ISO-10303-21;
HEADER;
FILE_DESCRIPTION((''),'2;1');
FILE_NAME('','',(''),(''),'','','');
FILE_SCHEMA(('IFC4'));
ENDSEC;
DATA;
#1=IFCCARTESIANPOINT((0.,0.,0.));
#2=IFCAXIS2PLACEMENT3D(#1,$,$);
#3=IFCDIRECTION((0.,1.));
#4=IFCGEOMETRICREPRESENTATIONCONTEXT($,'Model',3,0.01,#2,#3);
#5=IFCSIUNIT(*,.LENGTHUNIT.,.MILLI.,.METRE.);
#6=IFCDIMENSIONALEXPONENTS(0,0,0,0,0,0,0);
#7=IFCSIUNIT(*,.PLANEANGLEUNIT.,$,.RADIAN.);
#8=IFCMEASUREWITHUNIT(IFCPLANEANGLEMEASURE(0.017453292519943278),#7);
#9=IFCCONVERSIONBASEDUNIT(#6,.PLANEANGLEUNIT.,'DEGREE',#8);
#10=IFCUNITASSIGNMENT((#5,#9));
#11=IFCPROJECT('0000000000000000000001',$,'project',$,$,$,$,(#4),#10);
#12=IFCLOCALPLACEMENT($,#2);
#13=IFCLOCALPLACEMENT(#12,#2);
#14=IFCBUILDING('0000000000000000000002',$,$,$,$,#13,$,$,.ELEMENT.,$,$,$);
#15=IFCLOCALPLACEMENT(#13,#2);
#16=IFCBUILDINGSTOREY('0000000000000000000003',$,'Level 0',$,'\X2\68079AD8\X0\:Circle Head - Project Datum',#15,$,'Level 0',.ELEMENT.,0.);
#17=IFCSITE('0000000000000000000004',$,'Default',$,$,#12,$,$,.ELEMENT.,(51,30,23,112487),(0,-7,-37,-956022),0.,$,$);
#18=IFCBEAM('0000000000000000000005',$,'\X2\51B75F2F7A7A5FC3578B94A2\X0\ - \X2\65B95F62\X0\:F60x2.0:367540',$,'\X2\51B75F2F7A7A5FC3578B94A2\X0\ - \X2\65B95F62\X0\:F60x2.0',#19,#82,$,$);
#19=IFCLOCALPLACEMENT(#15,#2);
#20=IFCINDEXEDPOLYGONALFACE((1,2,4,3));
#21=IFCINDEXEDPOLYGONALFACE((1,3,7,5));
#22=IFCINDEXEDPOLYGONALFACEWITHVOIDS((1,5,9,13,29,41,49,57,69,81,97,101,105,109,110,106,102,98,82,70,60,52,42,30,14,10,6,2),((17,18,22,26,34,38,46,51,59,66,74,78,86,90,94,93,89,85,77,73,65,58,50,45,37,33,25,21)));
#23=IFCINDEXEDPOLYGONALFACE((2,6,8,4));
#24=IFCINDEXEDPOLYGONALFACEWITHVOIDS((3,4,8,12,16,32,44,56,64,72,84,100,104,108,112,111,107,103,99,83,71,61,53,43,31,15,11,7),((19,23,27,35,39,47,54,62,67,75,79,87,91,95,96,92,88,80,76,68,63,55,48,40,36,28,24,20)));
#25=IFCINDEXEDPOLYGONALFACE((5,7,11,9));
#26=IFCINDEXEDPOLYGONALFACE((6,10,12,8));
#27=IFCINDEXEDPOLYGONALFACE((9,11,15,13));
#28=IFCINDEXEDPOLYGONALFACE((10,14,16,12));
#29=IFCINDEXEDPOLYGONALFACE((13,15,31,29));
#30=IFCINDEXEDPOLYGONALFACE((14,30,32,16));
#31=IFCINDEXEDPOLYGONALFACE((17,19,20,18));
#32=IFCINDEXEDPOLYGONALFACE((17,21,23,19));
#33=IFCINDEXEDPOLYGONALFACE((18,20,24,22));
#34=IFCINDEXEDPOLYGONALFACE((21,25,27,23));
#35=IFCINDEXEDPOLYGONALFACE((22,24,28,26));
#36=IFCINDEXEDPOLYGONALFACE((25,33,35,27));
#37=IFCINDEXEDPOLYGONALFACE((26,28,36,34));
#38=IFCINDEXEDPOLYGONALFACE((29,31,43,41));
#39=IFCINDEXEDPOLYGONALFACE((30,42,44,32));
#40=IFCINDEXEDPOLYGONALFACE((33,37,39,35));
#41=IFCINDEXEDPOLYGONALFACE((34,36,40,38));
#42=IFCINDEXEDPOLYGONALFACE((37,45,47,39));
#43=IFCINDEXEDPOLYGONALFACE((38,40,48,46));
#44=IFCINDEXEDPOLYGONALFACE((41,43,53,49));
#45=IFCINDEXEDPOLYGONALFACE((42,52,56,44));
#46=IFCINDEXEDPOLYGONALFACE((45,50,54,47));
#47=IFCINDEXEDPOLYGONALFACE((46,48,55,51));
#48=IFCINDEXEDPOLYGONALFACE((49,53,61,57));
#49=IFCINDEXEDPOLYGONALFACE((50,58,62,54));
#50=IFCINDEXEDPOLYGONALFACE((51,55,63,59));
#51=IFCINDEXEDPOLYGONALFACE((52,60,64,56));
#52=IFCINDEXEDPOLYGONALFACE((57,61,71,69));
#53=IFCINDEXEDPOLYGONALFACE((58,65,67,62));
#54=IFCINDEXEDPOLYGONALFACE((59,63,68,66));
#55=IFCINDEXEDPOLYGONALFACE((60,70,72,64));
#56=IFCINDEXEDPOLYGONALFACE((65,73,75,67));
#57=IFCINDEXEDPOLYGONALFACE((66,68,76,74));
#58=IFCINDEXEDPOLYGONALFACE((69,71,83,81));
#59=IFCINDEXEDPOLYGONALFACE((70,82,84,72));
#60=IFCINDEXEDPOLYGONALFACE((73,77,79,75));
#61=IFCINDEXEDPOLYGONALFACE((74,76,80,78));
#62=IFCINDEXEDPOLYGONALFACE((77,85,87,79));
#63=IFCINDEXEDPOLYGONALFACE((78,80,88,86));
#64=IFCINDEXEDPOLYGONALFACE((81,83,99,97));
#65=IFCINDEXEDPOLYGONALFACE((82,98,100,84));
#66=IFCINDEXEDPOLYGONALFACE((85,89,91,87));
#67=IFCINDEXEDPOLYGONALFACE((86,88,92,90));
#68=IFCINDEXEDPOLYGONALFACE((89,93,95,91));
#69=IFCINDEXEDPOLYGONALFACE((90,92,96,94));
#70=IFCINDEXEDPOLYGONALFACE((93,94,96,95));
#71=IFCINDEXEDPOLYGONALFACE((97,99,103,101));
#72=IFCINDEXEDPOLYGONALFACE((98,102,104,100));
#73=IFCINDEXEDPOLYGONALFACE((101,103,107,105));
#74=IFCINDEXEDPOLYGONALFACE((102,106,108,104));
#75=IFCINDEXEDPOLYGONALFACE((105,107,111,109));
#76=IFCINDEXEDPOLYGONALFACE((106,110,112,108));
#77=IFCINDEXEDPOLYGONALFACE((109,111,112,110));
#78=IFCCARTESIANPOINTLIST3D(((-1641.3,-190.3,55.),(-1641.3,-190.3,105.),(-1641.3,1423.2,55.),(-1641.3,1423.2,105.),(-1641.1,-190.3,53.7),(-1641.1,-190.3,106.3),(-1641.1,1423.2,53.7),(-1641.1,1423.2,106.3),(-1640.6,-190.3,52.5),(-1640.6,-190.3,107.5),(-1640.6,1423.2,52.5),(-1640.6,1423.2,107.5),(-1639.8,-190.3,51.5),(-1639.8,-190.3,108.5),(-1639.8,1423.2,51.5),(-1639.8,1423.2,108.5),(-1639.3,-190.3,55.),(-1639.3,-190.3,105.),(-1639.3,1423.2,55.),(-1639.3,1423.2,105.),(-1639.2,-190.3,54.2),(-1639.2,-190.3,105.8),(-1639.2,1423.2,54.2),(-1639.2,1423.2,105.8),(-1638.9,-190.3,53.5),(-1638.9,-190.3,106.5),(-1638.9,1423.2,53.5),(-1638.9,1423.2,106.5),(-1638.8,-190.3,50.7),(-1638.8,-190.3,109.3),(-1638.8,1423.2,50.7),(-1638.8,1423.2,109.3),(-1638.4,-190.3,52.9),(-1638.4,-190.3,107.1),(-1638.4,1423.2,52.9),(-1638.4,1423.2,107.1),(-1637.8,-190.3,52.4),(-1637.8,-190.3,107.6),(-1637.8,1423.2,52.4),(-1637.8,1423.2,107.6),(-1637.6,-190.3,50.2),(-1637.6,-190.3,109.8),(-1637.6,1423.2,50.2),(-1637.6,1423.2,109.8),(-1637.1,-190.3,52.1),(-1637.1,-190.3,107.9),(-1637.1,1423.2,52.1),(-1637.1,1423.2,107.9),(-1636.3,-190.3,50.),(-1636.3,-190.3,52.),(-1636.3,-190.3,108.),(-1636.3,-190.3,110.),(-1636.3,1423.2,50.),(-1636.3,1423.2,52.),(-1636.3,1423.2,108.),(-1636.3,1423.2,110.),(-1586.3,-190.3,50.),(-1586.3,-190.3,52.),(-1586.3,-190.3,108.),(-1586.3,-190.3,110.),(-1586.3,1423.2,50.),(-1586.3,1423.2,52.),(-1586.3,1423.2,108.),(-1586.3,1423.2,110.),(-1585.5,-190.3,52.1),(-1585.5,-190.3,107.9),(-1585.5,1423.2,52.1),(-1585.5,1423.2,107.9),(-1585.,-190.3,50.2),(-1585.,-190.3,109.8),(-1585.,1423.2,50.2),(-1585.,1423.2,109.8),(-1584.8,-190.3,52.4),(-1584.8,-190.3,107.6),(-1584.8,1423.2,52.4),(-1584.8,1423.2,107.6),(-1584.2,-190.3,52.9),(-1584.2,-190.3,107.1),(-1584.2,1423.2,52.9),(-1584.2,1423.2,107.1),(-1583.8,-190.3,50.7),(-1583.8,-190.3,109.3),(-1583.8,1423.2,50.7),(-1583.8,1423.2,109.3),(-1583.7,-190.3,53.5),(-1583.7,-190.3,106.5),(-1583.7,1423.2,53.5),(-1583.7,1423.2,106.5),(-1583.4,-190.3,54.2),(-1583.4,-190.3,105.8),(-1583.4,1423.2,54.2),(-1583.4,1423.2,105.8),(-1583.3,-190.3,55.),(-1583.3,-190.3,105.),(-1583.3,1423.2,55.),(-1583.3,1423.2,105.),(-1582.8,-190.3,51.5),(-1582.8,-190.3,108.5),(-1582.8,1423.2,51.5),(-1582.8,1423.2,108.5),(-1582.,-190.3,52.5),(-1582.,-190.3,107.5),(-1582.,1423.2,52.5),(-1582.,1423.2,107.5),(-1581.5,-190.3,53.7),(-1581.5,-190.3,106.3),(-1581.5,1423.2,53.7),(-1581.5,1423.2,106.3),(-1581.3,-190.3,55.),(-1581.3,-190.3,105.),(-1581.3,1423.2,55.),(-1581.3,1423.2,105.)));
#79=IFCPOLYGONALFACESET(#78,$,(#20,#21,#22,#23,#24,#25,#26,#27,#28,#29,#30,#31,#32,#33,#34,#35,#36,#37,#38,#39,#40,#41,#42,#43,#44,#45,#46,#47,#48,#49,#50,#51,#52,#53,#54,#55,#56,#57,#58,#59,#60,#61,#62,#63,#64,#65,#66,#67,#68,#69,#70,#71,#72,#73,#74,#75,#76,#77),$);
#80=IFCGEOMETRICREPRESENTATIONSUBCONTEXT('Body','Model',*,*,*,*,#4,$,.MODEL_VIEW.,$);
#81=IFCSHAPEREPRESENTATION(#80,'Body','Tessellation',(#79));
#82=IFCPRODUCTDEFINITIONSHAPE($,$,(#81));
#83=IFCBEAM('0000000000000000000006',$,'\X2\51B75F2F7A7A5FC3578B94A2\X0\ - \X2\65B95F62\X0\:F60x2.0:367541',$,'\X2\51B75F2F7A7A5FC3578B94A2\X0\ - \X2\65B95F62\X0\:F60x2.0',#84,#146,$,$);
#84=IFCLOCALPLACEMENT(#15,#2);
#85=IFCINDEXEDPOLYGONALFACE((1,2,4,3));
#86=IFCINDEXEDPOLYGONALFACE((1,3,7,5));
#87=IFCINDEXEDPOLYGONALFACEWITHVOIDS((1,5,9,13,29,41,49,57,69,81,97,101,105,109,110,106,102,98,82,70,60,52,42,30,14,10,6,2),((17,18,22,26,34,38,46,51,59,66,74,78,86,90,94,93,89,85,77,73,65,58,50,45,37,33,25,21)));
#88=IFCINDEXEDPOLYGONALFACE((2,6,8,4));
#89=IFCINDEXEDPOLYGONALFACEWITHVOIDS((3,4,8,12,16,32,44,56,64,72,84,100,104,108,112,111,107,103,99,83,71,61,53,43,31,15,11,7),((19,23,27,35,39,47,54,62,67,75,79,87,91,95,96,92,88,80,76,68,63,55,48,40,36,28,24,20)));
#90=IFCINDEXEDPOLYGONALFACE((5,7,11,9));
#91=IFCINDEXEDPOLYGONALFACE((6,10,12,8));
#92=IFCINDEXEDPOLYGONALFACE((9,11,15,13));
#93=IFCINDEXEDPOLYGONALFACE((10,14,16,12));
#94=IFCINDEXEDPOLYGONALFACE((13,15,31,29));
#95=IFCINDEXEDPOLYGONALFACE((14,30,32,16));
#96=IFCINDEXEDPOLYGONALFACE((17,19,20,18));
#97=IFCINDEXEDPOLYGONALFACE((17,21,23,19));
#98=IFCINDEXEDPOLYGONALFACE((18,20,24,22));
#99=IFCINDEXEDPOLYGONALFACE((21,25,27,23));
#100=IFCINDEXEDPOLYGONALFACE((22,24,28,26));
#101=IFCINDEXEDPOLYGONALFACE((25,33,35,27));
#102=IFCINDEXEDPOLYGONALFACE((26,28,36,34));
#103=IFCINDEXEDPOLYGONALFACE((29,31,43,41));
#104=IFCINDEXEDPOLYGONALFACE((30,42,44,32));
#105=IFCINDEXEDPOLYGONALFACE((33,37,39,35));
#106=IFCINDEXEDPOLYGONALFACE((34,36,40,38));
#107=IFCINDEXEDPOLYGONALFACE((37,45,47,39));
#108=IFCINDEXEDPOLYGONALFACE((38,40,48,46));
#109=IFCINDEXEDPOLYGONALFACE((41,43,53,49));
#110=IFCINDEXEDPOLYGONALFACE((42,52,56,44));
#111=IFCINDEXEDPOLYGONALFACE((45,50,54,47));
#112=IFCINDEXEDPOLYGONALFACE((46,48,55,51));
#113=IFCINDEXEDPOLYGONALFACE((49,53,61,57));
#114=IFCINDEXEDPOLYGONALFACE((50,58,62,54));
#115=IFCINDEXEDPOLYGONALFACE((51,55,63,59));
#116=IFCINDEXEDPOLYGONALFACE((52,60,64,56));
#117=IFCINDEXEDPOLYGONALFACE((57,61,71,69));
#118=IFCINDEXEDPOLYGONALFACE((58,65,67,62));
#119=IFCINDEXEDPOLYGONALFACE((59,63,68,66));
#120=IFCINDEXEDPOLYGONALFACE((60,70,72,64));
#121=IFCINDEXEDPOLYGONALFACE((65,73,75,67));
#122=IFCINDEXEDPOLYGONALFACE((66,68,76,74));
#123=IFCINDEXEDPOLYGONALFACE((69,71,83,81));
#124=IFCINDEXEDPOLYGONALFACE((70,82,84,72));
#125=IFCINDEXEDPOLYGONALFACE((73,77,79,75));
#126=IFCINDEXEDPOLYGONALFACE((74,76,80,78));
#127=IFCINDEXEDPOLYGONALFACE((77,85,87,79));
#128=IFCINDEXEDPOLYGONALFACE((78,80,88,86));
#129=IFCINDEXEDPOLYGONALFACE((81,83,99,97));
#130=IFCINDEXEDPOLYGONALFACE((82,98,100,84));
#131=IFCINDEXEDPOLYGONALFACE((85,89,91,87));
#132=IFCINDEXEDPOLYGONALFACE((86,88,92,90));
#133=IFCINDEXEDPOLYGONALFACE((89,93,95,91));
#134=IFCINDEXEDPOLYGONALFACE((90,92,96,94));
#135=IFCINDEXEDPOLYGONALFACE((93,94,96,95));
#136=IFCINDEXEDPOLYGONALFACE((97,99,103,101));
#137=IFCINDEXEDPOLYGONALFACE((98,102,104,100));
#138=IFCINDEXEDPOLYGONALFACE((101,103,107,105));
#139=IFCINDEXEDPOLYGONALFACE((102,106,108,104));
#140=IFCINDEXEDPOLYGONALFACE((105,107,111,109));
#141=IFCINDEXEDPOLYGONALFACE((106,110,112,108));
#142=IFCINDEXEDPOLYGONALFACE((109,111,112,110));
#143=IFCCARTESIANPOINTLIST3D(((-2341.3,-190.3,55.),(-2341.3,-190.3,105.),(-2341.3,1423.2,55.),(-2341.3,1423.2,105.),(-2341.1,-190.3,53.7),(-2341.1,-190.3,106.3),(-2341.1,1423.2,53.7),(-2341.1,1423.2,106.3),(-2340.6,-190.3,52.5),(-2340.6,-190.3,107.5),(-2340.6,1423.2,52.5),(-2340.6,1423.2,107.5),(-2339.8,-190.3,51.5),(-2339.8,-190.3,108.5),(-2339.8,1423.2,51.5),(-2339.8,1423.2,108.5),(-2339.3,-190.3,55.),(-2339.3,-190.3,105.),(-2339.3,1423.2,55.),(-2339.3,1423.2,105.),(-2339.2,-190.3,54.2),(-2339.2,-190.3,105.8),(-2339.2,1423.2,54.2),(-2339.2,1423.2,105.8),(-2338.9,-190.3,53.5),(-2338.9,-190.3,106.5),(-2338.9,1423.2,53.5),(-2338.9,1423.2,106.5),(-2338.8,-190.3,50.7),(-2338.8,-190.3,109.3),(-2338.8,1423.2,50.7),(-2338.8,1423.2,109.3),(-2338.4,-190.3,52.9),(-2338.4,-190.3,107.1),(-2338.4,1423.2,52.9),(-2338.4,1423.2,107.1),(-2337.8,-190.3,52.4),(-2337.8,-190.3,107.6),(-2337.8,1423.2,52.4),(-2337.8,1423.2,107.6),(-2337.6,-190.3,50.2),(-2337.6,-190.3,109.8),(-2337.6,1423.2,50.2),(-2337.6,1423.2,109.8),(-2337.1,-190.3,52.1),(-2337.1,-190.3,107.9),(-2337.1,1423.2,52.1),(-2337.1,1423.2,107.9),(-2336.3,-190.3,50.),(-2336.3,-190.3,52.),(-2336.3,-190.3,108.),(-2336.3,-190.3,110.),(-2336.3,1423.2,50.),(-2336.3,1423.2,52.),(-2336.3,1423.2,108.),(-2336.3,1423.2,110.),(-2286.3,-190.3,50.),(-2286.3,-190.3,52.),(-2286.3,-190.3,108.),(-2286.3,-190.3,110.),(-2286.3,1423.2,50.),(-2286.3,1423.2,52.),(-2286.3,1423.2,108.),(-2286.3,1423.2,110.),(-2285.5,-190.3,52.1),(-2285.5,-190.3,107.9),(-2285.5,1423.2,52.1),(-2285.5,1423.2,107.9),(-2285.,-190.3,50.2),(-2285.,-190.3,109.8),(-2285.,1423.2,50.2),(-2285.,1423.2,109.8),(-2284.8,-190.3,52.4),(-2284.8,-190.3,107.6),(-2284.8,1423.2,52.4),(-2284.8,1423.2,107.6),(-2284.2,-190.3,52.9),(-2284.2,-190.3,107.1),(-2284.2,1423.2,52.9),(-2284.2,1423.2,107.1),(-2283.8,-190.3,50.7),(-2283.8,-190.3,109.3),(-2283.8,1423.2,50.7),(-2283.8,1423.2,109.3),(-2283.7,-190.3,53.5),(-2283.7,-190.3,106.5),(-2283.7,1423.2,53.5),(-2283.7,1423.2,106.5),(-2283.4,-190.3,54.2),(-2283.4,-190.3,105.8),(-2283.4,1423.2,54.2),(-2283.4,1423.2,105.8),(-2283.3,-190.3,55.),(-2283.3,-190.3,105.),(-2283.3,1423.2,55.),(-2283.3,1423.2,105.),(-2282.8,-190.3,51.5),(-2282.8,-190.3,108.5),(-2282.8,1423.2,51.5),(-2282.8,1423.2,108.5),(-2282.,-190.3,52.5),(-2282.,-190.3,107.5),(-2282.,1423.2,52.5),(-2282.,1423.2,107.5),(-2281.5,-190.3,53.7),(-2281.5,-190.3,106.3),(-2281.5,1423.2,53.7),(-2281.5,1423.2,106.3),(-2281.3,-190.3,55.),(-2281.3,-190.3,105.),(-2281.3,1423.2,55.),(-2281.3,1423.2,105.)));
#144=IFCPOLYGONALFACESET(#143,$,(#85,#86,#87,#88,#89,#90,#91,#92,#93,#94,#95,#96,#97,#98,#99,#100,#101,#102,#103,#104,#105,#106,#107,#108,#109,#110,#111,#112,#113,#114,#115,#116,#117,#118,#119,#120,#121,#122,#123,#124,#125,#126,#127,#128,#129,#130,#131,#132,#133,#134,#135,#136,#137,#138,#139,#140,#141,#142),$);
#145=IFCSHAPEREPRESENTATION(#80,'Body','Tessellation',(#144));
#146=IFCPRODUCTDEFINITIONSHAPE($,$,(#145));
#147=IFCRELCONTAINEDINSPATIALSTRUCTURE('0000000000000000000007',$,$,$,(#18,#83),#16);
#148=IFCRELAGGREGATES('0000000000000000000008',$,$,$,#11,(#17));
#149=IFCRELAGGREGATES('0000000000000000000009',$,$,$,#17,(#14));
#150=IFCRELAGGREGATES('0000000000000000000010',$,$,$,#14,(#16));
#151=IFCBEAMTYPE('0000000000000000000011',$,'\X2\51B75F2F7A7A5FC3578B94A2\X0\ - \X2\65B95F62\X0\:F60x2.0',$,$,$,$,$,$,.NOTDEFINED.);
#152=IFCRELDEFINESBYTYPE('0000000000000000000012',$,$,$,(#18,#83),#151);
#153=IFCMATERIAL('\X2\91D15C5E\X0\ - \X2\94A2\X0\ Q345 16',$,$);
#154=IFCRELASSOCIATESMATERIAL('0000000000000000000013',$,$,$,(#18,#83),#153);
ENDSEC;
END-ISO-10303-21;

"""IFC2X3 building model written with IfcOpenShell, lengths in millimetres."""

from ifc_helpers import new_model, entity, si_unit, converted_unit, direction, frame, frame_2d, origin, place, context, subcontext, project, spatial, polyline, circle_curve, parameter, trimmed, segment, composite_curve, outline, extrude, material, type_object, element, save


model = new_model("IFC2X3")

# Units and contexts
model_context = context("Model", 3, precision=0.01, world=origin(), true_north=direction((0.0, 1.0)))
body_context = subcontext(model_context, "Body", "Model", "MODEL_VIEW")
ifc_project = project(units=[si_unit("LENGTHUNIT", "METRE", prefix="MILLI"), converted_unit("PLANEANGLEUNIT", "DEGREE", entity("IfcPlaneAngleMeasure", 0.017453292519943278), si_unit("PLANEANGLEUNIT", "RADIAN"), dimensions=[0, 0, 0, 0, 0, 0, 0])], contexts=[model_context])

# Site, building, storey
site_placement = place(None, origin())
site = spatial("IfcSite", under=ifc_project, at=site_placement, Name="Default", CompositionType="ELEMENT", RefLatitude=(51, 30, 23, 112487), RefLongitude=(0, -7, -37, -956022), RefElevation=0.0)
building_placement = place(site_placement, origin())
building = spatial("IfcBuilding", under=site, at=building_placement, CompositionType="ELEMENT")
storey_placement = place(building_placement, origin())
storey = spatial("IfcBuildingStorey", under=building, at=storey_placement, Name="Level 0", ObjectType="标高:Circle Head - Project Datum", LongName="Level 0", CompositionType="ELEMENT", Elevation=0.0)

# Beams
ifc_material_1 = material(Name="金属 - 钢 Q345 16")
beam_type_1 = type_object("IfcBeamType", Name="冷弯空心型钢 - 方形:F60x2.0", PredefinedType="NOTDEFINED")
beam_1_placement = place(storey_placement, frame((-1611.3, 1388.1, 110.0), z_axis=(0.0, 0.0, 1.0), x_axis=(0.0, -1.0, 0.0)))
element("IfcBeam", 1, at=beam_1_placement, inside=storey, type_object=beam_type_1, material=ifc_material_1, Name="冷弯空心型钢 - 方形:F60x2.0:367540", ObjectType="冷弯空心型钢 - 方形:F60x2.0", context=body_context, shape_type="SweptSolid", body=[
    extrude(outline(composite_curve([segment(trimmed(circle_curve(frame_2d((-25.0, 25.0), x_axis=(1.0, 0.0)), 5.0), [parameter(90.0)], [parameter(180.0)], True, "PARAMETER"), True, "CONTINUOUS"), segment(polyline([(-30.0, 25.0), (-30.0, -25.0)]), True, "CONTINUOUS"), segment(trimmed(circle_curve(frame_2d((-25.0, -25.0), x_axis=(1.0, 0.0)), 5.0), [parameter(180.0)], [parameter(270.0)], True, "PARAMETER"), True, "CONTINUOUS"), segment(polyline([(-25.0, -30.0), (25.0, -30.0)]), True, "CONTINUOUS"), segment(trimmed(circle_curve(frame_2d((25.0, -25.0), x_axis=(1.0, 0.0)), 5.0), [parameter(270.0)], [parameter(0.0)], True, "PARAMETER"), True, "CONTINUOUS"), segment(polyline([(30.0, -25.0), (30.0, 25.0)]), True, "CONTINUOUS"), segment(trimmed(circle_curve(frame_2d((25.0, 25.0), x_axis=(1.0, 0.0)), 5.0), [parameter(0.0)], [parameter(90.0)], True, "PARAMETER"), True, "CONTINUOUS"), segment(polyline([(25.0, 30.0), (-25.0, 30.0)]), True, "CONTINUOUS")], self_intersect=False), holes=[composite_curve([segment(polyline([(-25.0, 28.0), (25.0, 28.0)]), True, "CONTINUOUS"), segment(trimmed(circle_curve(frame_2d((25.0, 25.0), x_axis=(1.0, 0.0)), 3.0), [parameter(0.0)], [parameter(90.0)], True, "PARAMETER"), False, "CONTINUOUS"), segment(polyline([(28.0, 25.0), (28.0, -25.0)]), True, "CONTINUOUS"), segment(trimmed(circle_curve(frame_2d((25.0, -25.0), x_axis=(1.0, 0.0)), 3.0), [parameter(270.0)], [parameter(360.0)], True, "PARAMETER"), False, "CONTINUOUS"), segment(polyline([(25.0, -28.0), (-25.0, -28.0)]), True, "CONTINUOUS"), segment(trimmed(circle_curve(frame_2d((-25.0, -25.0), x_axis=(1.0, 0.0)), 3.0), [parameter(180.0)], [parameter(270.0)], True, "PARAMETER"), False, "CONTINUOUS"), segment(polyline([(-28.0, -25.0), (-28.0, 25.0)]), True, "CONTINUOUS"), segment(trimmed(circle_curve(frame_2d((-25.0, 25.0), x_axis=(1.0, 0.0)), 3.0), [parameter(90.0)], [parameter(180.0)], True, "PARAMETER"), False, "CONTINUOUS")], self_intersect=False)]), frame((-35.1, 0.0, -30.0), z_axis=(1.0, 0.0, 0.0), x_axis=(0.0, 1.0, 0.0)), (0.0, 0.0, 1.0), 1613.5),
])
beam_2_placement = place(storey_placement, frame((-2311.3, 1388.1, 110.0), z_axis=(0.0, 0.0, 1.0), x_axis=(0.0, -1.0, 0.0)))
element("IfcBeam", 2, at=beam_2_placement, inside=storey, type_object=beam_type_1, material=ifc_material_1, Name="冷弯空心型钢 - 方形:F60x2.0:367541", ObjectType="冷弯空心型钢 - 方形:F60x2.0", context=body_context, shape_type="SweptSolid", body=[
    extrude(outline(composite_curve([segment(trimmed(circle_curve(frame_2d((-25.0, 25.0), x_axis=(1.0, 0.0)), 5.0), [parameter(90.0)], [parameter(180.0)], True, "PARAMETER"), True, "CONTINUOUS"), segment(polyline([(-30.0, 25.0), (-30.0, -25.0)]), True, "CONTINUOUS"), segment(trimmed(circle_curve(frame_2d((-25.0, -25.0), x_axis=(1.0, 0.0)), 5.0), [parameter(180.0)], [parameter(270.0)], True, "PARAMETER"), True, "CONTINUOUS"), segment(polyline([(-25.0, -30.0), (25.0, -30.0)]), True, "CONTINUOUS"), segment(trimmed(circle_curve(frame_2d((25.0, -25.0), x_axis=(1.0, 0.0)), 5.0), [parameter(270.0)], [parameter(0.0)], True, "PARAMETER"), True, "CONTINUOUS"), segment(polyline([(30.0, -25.0), (30.0, 25.0)]), True, "CONTINUOUS"), segment(trimmed(circle_curve(frame_2d((25.0, 25.0), x_axis=(1.0, 0.0)), 5.0), [parameter(0.0)], [parameter(90.0)], True, "PARAMETER"), True, "CONTINUOUS"), segment(polyline([(25.0, 30.0), (-25.0, 30.0)]), True, "CONTINUOUS")], self_intersect=False), holes=[composite_curve([segment(polyline([(-25.0, 28.0), (25.0, 28.0)]), True, "CONTINUOUS"), segment(trimmed(circle_curve(frame_2d((25.0, 25.0), x_axis=(1.0, 0.0)), 3.0), [parameter(0.0)], [parameter(90.0)], True, "PARAMETER"), False, "CONTINUOUS"), segment(polyline([(28.0, 25.0), (28.0, -25.0)]), True, "CONTINUOUS"), segment(trimmed(circle_curve(frame_2d((25.0, -25.0), x_axis=(1.0, 0.0)), 3.0), [parameter(270.0)], [parameter(360.0)], True, "PARAMETER"), False, "CONTINUOUS"), segment(polyline([(25.0, -28.0), (-25.0, -28.0)]), True, "CONTINUOUS"), segment(trimmed(circle_curve(frame_2d((-25.0, -25.0), x_axis=(1.0, 0.0)), 3.0), [parameter(180.0)], [parameter(270.0)], True, "PARAMETER"), False, "CONTINUOUS"), segment(polyline([(-28.0, -25.0), (-28.0, 25.0)]), True, "CONTINUOUS"), segment(trimmed(circle_curve(frame_2d((-25.0, 25.0), x_axis=(1.0, 0.0)), 3.0), [parameter(90.0)], [parameter(180.0)], True, "PARAMETER"), False, "CONTINUOUS")], self_intersect=False)]), frame((-35.1, 0.0, -30.0), z_axis=(1.0, 0.0, 0.0), x_axis=(0.0, 1.0, 0.0)), (0.0, 0.0, 1.0), 1613.5),
])

save(model, "model.ifc")
